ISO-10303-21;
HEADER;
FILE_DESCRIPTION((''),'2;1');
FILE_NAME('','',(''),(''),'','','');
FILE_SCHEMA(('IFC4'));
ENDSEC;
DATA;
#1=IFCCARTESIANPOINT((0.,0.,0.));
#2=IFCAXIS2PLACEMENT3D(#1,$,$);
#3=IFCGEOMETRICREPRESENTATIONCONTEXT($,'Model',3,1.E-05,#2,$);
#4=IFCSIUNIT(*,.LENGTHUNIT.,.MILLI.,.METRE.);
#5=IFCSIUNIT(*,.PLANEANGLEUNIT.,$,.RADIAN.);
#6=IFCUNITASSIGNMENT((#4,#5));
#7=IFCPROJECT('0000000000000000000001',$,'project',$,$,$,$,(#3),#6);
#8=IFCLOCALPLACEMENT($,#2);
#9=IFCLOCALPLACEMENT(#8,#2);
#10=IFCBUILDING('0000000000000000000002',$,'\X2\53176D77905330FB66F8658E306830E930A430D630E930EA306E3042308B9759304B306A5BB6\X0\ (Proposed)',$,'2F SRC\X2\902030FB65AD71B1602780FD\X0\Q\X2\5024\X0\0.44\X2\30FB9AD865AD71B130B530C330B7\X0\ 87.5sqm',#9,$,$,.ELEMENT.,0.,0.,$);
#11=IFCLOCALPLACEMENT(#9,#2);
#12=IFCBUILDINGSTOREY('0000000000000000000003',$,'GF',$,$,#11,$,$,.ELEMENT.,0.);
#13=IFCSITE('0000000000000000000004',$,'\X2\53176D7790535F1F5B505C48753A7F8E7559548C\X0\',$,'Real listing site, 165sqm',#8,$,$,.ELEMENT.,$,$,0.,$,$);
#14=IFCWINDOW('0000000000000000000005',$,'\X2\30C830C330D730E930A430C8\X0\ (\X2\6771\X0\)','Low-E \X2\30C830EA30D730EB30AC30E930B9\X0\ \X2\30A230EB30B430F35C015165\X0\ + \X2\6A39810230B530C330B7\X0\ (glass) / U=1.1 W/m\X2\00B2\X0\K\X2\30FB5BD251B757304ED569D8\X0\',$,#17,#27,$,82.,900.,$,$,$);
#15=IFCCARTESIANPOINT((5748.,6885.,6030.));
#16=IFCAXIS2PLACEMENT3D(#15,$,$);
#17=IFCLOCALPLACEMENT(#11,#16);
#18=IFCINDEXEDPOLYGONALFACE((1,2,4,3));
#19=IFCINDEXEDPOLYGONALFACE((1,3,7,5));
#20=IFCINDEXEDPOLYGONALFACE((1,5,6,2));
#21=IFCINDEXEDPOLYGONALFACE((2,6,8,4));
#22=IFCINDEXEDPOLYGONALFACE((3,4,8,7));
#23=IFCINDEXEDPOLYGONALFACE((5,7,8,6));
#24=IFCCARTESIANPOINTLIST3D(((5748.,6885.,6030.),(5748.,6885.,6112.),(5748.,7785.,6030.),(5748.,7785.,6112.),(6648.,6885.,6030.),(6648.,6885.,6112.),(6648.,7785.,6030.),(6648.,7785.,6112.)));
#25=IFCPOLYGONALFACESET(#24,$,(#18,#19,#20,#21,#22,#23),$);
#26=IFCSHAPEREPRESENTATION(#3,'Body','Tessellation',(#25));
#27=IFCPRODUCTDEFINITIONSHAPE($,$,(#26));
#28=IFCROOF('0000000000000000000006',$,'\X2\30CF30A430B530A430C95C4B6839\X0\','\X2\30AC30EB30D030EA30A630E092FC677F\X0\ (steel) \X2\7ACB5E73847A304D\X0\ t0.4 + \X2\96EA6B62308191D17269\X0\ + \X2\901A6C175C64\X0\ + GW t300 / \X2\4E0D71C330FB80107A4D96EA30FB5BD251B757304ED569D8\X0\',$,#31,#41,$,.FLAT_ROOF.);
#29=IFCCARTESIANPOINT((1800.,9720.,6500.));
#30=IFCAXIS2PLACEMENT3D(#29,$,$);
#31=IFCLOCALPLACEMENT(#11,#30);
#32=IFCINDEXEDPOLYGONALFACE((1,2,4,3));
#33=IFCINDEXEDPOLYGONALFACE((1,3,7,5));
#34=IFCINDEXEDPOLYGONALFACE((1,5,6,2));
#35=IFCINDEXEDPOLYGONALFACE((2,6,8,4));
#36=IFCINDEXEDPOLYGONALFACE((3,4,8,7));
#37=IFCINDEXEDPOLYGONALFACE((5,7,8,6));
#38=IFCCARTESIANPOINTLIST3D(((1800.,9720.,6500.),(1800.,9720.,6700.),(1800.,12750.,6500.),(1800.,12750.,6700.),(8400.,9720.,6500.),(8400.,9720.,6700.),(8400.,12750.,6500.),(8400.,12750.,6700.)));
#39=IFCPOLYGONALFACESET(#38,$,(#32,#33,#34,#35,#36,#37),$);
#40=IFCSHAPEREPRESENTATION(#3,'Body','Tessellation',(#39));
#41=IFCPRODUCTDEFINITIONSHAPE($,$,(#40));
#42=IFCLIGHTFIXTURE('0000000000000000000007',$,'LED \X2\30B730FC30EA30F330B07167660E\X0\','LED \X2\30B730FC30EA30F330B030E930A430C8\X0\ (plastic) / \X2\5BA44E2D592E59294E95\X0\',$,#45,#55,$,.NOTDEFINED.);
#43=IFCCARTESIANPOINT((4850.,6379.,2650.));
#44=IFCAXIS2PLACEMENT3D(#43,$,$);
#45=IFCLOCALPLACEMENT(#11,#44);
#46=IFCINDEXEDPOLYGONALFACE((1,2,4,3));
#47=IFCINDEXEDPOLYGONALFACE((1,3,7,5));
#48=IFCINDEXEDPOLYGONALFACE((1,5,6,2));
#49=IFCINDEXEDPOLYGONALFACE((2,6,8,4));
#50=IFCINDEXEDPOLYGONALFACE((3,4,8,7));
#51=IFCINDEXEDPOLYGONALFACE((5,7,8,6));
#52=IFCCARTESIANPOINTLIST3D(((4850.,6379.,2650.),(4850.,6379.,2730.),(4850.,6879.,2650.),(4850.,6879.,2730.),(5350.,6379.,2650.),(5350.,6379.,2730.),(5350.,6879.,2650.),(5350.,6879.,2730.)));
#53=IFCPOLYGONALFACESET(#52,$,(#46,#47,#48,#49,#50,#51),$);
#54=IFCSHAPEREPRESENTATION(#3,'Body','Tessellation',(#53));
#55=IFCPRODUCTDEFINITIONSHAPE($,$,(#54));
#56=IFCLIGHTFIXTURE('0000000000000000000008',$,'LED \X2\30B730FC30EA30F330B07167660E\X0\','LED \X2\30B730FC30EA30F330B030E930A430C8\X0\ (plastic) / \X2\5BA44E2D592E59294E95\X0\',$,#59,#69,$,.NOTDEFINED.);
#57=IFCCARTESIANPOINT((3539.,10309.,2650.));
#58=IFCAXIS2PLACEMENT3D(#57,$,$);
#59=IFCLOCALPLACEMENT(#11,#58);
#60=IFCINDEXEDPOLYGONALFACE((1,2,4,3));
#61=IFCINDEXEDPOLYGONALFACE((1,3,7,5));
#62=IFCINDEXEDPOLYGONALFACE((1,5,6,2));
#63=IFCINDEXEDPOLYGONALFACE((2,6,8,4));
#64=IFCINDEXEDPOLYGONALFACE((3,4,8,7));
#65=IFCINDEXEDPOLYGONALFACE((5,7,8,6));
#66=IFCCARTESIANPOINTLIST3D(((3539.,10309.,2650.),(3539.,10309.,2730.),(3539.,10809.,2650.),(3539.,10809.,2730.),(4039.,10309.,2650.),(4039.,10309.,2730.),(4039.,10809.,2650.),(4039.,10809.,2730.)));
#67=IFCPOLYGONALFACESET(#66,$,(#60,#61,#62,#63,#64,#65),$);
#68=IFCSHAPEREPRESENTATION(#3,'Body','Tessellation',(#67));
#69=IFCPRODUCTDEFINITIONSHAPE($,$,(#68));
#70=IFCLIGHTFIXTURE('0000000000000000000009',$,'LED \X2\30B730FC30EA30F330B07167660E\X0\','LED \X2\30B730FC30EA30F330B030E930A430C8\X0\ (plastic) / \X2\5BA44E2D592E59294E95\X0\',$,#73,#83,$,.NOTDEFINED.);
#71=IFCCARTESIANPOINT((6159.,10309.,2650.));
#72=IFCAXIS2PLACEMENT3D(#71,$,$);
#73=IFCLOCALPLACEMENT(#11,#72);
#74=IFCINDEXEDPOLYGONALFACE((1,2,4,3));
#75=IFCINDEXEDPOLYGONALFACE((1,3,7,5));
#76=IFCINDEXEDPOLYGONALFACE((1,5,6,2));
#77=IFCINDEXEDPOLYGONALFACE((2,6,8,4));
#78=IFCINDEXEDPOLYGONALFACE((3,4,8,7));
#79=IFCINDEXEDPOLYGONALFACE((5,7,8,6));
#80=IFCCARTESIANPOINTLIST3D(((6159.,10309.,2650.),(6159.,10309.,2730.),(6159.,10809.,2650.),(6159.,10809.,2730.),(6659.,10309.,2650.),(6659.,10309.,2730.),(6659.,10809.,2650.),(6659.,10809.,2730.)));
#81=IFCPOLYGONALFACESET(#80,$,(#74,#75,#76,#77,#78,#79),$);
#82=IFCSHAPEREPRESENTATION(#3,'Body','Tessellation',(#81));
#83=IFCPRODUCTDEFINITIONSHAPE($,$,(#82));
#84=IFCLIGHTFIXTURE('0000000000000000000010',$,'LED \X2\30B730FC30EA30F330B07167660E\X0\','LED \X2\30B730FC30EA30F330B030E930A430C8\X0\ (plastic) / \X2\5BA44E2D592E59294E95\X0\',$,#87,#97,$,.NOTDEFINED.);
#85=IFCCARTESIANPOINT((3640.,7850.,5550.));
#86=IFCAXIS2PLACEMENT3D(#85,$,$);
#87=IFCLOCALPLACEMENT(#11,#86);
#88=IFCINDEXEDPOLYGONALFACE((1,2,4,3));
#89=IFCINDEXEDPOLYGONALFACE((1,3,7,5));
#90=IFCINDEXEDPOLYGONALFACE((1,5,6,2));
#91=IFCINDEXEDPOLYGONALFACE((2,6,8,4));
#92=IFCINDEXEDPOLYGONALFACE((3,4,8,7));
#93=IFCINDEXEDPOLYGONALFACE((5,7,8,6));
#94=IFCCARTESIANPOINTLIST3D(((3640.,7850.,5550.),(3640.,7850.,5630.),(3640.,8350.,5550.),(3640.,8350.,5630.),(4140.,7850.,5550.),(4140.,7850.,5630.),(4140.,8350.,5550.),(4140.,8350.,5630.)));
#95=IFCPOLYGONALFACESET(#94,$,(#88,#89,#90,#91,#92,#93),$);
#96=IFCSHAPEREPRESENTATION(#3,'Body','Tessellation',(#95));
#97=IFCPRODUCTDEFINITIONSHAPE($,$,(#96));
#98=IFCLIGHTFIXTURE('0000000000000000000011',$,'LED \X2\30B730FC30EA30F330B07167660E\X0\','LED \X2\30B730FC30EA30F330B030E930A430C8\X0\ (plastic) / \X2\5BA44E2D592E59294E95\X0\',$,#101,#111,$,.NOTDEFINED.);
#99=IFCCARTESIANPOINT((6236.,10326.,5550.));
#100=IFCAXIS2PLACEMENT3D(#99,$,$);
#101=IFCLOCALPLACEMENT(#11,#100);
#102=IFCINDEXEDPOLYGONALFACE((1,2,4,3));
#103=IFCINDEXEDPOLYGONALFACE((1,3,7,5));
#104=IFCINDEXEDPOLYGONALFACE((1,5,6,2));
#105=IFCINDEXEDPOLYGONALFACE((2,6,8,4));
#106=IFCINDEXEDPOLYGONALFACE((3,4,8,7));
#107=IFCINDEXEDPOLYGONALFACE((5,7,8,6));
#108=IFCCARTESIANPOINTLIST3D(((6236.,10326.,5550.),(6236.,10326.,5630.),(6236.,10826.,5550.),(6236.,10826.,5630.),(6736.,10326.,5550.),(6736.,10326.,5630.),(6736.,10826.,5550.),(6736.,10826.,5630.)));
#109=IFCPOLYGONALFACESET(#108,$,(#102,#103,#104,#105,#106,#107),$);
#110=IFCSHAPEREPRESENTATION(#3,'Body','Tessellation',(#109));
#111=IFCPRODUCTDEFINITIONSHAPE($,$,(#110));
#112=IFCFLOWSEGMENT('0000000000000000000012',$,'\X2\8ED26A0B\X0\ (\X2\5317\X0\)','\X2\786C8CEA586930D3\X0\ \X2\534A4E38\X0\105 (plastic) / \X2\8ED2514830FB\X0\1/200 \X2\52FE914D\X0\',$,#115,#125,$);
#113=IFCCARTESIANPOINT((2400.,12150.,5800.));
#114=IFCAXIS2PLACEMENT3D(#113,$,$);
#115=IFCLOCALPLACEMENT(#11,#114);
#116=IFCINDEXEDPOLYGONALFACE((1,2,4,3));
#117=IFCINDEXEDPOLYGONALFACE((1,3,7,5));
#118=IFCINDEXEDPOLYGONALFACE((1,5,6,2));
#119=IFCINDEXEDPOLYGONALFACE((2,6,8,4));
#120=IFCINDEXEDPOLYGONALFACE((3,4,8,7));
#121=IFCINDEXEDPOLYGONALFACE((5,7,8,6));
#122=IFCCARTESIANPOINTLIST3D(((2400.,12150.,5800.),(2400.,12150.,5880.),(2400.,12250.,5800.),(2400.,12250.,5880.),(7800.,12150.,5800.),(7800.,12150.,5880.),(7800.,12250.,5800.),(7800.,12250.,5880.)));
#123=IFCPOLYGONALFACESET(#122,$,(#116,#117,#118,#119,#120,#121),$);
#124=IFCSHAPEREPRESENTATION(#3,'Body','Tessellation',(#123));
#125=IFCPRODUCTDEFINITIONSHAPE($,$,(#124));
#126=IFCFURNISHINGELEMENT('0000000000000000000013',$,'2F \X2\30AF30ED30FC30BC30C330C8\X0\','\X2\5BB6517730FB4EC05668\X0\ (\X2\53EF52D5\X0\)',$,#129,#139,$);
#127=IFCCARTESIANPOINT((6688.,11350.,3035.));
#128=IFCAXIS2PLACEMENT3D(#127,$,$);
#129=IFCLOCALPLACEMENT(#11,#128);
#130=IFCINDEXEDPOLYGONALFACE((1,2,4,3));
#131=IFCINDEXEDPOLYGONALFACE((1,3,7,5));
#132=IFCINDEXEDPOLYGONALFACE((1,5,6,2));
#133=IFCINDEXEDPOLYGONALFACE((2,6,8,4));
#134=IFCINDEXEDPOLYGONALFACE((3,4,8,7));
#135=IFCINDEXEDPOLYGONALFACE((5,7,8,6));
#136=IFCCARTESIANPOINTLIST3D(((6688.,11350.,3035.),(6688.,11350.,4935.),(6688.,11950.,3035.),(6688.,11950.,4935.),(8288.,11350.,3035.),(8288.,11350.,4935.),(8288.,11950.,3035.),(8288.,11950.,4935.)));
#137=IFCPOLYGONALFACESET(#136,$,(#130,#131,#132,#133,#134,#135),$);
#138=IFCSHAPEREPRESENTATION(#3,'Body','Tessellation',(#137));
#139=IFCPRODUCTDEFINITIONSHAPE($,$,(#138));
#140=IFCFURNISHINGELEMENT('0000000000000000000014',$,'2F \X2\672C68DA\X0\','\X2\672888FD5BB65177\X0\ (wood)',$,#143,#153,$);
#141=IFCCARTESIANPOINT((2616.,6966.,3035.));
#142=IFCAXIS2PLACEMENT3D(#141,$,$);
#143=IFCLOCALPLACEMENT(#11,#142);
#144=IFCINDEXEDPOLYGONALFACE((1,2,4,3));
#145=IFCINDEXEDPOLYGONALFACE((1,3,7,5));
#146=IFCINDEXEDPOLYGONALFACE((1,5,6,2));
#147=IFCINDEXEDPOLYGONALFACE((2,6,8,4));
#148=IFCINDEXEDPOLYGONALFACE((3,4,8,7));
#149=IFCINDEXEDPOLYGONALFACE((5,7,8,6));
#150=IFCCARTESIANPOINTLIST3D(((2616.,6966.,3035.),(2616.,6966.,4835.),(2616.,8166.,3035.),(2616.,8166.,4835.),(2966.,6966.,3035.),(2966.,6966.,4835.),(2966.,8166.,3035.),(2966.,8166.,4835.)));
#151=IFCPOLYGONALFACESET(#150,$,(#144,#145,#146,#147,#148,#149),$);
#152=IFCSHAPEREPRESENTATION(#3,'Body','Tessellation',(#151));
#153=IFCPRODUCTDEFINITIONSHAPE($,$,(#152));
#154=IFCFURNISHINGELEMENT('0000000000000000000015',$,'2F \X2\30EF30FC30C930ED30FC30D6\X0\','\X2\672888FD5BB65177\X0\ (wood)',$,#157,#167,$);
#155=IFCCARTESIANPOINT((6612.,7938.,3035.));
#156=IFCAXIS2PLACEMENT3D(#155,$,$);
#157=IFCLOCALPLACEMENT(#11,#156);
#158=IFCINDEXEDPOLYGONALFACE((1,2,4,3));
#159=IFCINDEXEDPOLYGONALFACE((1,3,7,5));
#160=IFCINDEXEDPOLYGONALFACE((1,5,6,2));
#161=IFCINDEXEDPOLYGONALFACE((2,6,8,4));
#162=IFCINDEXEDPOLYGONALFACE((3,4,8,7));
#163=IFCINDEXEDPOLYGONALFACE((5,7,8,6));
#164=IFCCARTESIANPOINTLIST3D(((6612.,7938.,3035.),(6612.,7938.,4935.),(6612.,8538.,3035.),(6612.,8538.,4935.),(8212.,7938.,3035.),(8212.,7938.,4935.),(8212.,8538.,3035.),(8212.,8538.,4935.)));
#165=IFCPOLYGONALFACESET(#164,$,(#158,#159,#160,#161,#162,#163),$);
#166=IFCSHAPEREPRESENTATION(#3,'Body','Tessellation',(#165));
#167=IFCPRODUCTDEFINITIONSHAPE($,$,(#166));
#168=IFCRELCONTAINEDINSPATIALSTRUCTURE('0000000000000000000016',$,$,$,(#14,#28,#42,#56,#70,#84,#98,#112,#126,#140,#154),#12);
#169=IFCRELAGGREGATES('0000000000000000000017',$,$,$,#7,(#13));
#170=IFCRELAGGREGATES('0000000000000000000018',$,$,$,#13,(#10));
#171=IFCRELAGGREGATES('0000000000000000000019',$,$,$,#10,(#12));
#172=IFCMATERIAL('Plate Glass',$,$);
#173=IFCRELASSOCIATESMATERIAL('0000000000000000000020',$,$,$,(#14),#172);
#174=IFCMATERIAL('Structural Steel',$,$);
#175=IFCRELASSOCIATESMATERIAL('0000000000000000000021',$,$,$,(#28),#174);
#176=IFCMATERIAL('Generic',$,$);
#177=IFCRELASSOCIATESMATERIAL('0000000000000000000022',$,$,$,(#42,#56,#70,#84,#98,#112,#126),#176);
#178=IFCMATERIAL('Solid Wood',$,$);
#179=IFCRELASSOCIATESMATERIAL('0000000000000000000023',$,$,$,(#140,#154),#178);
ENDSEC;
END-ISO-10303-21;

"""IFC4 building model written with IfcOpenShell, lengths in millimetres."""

from ifc_helpers import new_model, si_unit, frame, frame_2d, origin, place, context, project, spatial, rectangle, extrude, material, element, save


model = new_model("IFC4")

# Units and contexts
model_context = context("Model", 3, precision=1e-05, world=origin())
ifc_project = project(units=[si_unit("LENGTHUNIT", "METRE", prefix="MILLI"), si_unit("PLANEANGLEUNIT", "RADIAN")], contexts=[model_context])

# Site, building, storey
site_placement = place(None, origin())
site = spatial("IfcSite", under=ifc_project, at=site_placement, Name="北海道弟子屈町美留和", ObjectType="Real listing site, 165sqm", CompositionType="ELEMENT", RefElevation=0.0)
building_placement = place(site_placement, origin())
building = spatial("IfcBuilding", under=site, at=building_placement, Name="北海道・書斎とライブラリのある静かな家 (Proposed)", ObjectType="2F SRC造・断熱性能Q値0.44・高断熱サッシ 87.5sqm", CompositionType="ELEMENT", ElevationOfRefHeight=0.0, ElevationOfTerrain=0.0)
storey_placement = place(building_placement, origin())
storey = spatial("IfcBuildingStorey", under=building, at=storey_placement, Name="GF", CompositionType="ELEMENT", Elevation=0.0)

# Shared definitions
ifc_material_1 = material(Name="Solid Wood")

# Shared definitions
ifc_material_2 = material(Name="Plate Glass")

# Window
window_1_placement = place(storey_placement, frame((5748.0, 6885.0, 6030.0)))
element("IfcWindow", 1, at=window_1_placement, inside=storey, material=ifc_material_2, Name="トップライト (東)", Description="Low-E トリプルガラス アルゴン封入 + 樹脂サッシ (glass) / U=1.1 W/m²K・寒冷地仕様", OverallHeight=82.0, OverallWidth=900.0, context=model_context, shape_type="SweptSolid", body=[
    extrude(rectangle(XDim=900.0, YDim=900.0, at=frame_2d((450.0, 450.0))), frame((5748.0, 6885.0, 6030.0)), (0.0, 0.0, 1.0), 82.0),
])

# Roof
ifc_material_3 = material(Name="Structural Steel")
roof_placement = place(storey_placement, frame((1800.0, 9720.0, 6500.0)))
element("IfcRoof", 2, at=roof_placement, inside=storey, material=ifc_material_3, Name="ハイサイド屋根", Description="ガルバリウム鋼板 (steel) 立平葺き t0.4 + 雪止め金物 + 通気層 + GW t300 / 不燃・耐積雪・寒冷地仕様", PredefinedType="FLAT_ROOF", context=model_context, shape_type="SweptSolid", body=[
    extrude(rectangle(XDim=6600.0, YDim=3030.0, at=frame_2d((3300.0, 1515.0))), frame((1800.0, 9720.0, 6500.0)), (0.0, 0.0, 1.0), 200.0),
])

# Light fixtures
ifc_material_4 = material(Name="Generic")
light_fixture_1_placement = place(storey_placement, frame((4850.0, 6379.0, 2650.0)))
element("IfcLightFixture", 3, at=light_fixture_1_placement, inside=storey, material=ifc_material_4, Name="LED シーリング照明", Description="LED シーリングライト (plastic) / 室中央天井", PredefinedType="NOTDEFINED", context=model_context, shape_type="SweptSolid", body=[
    extrude(rectangle(XDim=500.0, YDim=500.0, at=frame_2d((250.0, 250.0))), frame((4850.0, 6379.0, 2650.0)), (0.0, 0.0, 1.0), 80.0),
])
light_fixture_2_placement = place(storey_placement, frame((3539.0, 10309.0, 2650.0)))
element("IfcLightFixture", 4, at=light_fixture_2_placement, inside=storey, material=ifc_material_4, Name="LED シーリング照明", Description="LED シーリングライト (plastic) / 室中央天井", PredefinedType="NOTDEFINED", context=model_context, shape_type="SweptSolid", body=[
    extrude(rectangle(XDim=500.0, YDim=500.0, at=frame_2d((250.0, 250.0))), frame((3539.0, 10309.0, 2650.0)), (0.0, 0.0, 1.0), 80.0),
])
light_fixture_3_placement = place(storey_placement, frame((6159.0, 10309.0, 2650.0)))
element("IfcLightFixture", 5, at=light_fixture_3_placement, inside=storey, material=ifc_material_4, Name="LED シーリング照明", Description="LED シーリングライト (plastic) / 室中央天井", PredefinedType="NOTDEFINED", context=model_context, shape_type="SweptSolid", body=[
    extrude(rectangle(XDim=500.0, YDim=500.0, at=frame_2d((250.0, 250.0))), frame((6159.0, 10309.0, 2650.0)), (0.0, 0.0, 1.0), 80.0),
])
light_fixture_4_placement = place(storey_placement, frame((3640.0, 7850.0, 5550.0)))
element("IfcLightFixture", 6, at=light_fixture_4_placement, inside=storey, material=ifc_material_4, Name="LED シーリング照明", Description="LED シーリングライト (plastic) / 室中央天井", PredefinedType="NOTDEFINED", context=model_context, shape_type="SweptSolid", body=[
    extrude(rectangle(XDim=500.0, YDim=500.0, at=frame_2d((250.0, 250.0))), frame((3640.0, 7850.0, 5550.0)), (0.0, 0.0, 1.0), 80.0),
])
light_fixture_5_placement = place(storey_placement, frame((6236.0, 10326.0, 5550.0)))
element("IfcLightFixture", 7, at=light_fixture_5_placement, inside=storey, material=ifc_material_4, Name="LED シーリング照明", Description="LED シーリングライト (plastic) / 室中央天井", PredefinedType="NOTDEFINED", context=model_context, shape_type="SweptSolid", body=[
    extrude(rectangle(XDim=500.0, YDim=500.0, at=frame_2d((250.0, 250.0))), frame((6236.0, 10326.0, 5550.0)), (0.0, 0.0, 1.0), 80.0),
])

# Flow segment
flow_segment_placement = place(storey_placement, frame((2400.0, 12150.0, 5800.0)))
element("IfcFlowSegment", 8, at=flow_segment_placement, inside=storey, material=ifc_material_4, Name="軒樋 (北)", Description="硬質塩ビ 半丸105 (plastic) / 軒先・1/200 勾配", context=model_context, shape_type="SweptSolid", body=[
    extrude(rectangle(XDim=5400.0, YDim=100.0, at=frame_2d((2700.0, 50.0))), frame((2400.0, 12150.0, 5800.0)), (0.0, 0.0, 1.0), 80.0),
])

# Furnishing elements
furnishing_1_placement = place(storey_placement, frame((6688.0, 11350.0, 3035.0)))
element("IfcFurnishingElement", 9, at=furnishing_1_placement, inside=storey, material=ifc_material_4, Name="2F クローゼット", Description="家具・什器 (可動)", context=model_context, shape_type="SweptSolid", body=[
    extrude(rectangle(XDim=1600.0, YDim=600.0, at=frame_2d((800.0, 300.0))), frame((6688.0, 11350.0, 3035.0)), (0.0, 0.0, 1.0), 1900.0),
])
furnishing_2_placement = place(storey_placement, frame((2616.0, 6966.0, 3035.0)))
element("IfcFurnishingElement", 10, at=furnishing_2_placement, inside=storey, material=ifc_material_1, Name="2F 本棚", Description="木製家具 (wood)", context=model_context, shape_type="SweptSolid", body=[
    extrude(rectangle(XDim=350.0, YDim=1200.0, at=frame_2d((175.0, 600.0))), frame((2616.0, 6966.0, 3035.0)), (0.0, 0.0, 1.0), 1800.0),
])
furnishing_3_placement = place(storey_placement, frame((6612.0, 7938.0, 3035.0)))
element("IfcFurnishingElement", 11, at=furnishing_3_placement, inside=storey, material=ifc_material_1, Name="2F ワードローブ", Description="木製家具 (wood)", context=model_context, shape_type="SweptSolid", body=[
    extrude(rectangle(XDim=1600.0, YDim=600.0, at=frame_2d((800.0, 300.0))), frame((6612.0, 7938.0, 3035.0)), (0.0, 0.0, 1.0), 1900.0),
])

save(model, "model.ifc")
